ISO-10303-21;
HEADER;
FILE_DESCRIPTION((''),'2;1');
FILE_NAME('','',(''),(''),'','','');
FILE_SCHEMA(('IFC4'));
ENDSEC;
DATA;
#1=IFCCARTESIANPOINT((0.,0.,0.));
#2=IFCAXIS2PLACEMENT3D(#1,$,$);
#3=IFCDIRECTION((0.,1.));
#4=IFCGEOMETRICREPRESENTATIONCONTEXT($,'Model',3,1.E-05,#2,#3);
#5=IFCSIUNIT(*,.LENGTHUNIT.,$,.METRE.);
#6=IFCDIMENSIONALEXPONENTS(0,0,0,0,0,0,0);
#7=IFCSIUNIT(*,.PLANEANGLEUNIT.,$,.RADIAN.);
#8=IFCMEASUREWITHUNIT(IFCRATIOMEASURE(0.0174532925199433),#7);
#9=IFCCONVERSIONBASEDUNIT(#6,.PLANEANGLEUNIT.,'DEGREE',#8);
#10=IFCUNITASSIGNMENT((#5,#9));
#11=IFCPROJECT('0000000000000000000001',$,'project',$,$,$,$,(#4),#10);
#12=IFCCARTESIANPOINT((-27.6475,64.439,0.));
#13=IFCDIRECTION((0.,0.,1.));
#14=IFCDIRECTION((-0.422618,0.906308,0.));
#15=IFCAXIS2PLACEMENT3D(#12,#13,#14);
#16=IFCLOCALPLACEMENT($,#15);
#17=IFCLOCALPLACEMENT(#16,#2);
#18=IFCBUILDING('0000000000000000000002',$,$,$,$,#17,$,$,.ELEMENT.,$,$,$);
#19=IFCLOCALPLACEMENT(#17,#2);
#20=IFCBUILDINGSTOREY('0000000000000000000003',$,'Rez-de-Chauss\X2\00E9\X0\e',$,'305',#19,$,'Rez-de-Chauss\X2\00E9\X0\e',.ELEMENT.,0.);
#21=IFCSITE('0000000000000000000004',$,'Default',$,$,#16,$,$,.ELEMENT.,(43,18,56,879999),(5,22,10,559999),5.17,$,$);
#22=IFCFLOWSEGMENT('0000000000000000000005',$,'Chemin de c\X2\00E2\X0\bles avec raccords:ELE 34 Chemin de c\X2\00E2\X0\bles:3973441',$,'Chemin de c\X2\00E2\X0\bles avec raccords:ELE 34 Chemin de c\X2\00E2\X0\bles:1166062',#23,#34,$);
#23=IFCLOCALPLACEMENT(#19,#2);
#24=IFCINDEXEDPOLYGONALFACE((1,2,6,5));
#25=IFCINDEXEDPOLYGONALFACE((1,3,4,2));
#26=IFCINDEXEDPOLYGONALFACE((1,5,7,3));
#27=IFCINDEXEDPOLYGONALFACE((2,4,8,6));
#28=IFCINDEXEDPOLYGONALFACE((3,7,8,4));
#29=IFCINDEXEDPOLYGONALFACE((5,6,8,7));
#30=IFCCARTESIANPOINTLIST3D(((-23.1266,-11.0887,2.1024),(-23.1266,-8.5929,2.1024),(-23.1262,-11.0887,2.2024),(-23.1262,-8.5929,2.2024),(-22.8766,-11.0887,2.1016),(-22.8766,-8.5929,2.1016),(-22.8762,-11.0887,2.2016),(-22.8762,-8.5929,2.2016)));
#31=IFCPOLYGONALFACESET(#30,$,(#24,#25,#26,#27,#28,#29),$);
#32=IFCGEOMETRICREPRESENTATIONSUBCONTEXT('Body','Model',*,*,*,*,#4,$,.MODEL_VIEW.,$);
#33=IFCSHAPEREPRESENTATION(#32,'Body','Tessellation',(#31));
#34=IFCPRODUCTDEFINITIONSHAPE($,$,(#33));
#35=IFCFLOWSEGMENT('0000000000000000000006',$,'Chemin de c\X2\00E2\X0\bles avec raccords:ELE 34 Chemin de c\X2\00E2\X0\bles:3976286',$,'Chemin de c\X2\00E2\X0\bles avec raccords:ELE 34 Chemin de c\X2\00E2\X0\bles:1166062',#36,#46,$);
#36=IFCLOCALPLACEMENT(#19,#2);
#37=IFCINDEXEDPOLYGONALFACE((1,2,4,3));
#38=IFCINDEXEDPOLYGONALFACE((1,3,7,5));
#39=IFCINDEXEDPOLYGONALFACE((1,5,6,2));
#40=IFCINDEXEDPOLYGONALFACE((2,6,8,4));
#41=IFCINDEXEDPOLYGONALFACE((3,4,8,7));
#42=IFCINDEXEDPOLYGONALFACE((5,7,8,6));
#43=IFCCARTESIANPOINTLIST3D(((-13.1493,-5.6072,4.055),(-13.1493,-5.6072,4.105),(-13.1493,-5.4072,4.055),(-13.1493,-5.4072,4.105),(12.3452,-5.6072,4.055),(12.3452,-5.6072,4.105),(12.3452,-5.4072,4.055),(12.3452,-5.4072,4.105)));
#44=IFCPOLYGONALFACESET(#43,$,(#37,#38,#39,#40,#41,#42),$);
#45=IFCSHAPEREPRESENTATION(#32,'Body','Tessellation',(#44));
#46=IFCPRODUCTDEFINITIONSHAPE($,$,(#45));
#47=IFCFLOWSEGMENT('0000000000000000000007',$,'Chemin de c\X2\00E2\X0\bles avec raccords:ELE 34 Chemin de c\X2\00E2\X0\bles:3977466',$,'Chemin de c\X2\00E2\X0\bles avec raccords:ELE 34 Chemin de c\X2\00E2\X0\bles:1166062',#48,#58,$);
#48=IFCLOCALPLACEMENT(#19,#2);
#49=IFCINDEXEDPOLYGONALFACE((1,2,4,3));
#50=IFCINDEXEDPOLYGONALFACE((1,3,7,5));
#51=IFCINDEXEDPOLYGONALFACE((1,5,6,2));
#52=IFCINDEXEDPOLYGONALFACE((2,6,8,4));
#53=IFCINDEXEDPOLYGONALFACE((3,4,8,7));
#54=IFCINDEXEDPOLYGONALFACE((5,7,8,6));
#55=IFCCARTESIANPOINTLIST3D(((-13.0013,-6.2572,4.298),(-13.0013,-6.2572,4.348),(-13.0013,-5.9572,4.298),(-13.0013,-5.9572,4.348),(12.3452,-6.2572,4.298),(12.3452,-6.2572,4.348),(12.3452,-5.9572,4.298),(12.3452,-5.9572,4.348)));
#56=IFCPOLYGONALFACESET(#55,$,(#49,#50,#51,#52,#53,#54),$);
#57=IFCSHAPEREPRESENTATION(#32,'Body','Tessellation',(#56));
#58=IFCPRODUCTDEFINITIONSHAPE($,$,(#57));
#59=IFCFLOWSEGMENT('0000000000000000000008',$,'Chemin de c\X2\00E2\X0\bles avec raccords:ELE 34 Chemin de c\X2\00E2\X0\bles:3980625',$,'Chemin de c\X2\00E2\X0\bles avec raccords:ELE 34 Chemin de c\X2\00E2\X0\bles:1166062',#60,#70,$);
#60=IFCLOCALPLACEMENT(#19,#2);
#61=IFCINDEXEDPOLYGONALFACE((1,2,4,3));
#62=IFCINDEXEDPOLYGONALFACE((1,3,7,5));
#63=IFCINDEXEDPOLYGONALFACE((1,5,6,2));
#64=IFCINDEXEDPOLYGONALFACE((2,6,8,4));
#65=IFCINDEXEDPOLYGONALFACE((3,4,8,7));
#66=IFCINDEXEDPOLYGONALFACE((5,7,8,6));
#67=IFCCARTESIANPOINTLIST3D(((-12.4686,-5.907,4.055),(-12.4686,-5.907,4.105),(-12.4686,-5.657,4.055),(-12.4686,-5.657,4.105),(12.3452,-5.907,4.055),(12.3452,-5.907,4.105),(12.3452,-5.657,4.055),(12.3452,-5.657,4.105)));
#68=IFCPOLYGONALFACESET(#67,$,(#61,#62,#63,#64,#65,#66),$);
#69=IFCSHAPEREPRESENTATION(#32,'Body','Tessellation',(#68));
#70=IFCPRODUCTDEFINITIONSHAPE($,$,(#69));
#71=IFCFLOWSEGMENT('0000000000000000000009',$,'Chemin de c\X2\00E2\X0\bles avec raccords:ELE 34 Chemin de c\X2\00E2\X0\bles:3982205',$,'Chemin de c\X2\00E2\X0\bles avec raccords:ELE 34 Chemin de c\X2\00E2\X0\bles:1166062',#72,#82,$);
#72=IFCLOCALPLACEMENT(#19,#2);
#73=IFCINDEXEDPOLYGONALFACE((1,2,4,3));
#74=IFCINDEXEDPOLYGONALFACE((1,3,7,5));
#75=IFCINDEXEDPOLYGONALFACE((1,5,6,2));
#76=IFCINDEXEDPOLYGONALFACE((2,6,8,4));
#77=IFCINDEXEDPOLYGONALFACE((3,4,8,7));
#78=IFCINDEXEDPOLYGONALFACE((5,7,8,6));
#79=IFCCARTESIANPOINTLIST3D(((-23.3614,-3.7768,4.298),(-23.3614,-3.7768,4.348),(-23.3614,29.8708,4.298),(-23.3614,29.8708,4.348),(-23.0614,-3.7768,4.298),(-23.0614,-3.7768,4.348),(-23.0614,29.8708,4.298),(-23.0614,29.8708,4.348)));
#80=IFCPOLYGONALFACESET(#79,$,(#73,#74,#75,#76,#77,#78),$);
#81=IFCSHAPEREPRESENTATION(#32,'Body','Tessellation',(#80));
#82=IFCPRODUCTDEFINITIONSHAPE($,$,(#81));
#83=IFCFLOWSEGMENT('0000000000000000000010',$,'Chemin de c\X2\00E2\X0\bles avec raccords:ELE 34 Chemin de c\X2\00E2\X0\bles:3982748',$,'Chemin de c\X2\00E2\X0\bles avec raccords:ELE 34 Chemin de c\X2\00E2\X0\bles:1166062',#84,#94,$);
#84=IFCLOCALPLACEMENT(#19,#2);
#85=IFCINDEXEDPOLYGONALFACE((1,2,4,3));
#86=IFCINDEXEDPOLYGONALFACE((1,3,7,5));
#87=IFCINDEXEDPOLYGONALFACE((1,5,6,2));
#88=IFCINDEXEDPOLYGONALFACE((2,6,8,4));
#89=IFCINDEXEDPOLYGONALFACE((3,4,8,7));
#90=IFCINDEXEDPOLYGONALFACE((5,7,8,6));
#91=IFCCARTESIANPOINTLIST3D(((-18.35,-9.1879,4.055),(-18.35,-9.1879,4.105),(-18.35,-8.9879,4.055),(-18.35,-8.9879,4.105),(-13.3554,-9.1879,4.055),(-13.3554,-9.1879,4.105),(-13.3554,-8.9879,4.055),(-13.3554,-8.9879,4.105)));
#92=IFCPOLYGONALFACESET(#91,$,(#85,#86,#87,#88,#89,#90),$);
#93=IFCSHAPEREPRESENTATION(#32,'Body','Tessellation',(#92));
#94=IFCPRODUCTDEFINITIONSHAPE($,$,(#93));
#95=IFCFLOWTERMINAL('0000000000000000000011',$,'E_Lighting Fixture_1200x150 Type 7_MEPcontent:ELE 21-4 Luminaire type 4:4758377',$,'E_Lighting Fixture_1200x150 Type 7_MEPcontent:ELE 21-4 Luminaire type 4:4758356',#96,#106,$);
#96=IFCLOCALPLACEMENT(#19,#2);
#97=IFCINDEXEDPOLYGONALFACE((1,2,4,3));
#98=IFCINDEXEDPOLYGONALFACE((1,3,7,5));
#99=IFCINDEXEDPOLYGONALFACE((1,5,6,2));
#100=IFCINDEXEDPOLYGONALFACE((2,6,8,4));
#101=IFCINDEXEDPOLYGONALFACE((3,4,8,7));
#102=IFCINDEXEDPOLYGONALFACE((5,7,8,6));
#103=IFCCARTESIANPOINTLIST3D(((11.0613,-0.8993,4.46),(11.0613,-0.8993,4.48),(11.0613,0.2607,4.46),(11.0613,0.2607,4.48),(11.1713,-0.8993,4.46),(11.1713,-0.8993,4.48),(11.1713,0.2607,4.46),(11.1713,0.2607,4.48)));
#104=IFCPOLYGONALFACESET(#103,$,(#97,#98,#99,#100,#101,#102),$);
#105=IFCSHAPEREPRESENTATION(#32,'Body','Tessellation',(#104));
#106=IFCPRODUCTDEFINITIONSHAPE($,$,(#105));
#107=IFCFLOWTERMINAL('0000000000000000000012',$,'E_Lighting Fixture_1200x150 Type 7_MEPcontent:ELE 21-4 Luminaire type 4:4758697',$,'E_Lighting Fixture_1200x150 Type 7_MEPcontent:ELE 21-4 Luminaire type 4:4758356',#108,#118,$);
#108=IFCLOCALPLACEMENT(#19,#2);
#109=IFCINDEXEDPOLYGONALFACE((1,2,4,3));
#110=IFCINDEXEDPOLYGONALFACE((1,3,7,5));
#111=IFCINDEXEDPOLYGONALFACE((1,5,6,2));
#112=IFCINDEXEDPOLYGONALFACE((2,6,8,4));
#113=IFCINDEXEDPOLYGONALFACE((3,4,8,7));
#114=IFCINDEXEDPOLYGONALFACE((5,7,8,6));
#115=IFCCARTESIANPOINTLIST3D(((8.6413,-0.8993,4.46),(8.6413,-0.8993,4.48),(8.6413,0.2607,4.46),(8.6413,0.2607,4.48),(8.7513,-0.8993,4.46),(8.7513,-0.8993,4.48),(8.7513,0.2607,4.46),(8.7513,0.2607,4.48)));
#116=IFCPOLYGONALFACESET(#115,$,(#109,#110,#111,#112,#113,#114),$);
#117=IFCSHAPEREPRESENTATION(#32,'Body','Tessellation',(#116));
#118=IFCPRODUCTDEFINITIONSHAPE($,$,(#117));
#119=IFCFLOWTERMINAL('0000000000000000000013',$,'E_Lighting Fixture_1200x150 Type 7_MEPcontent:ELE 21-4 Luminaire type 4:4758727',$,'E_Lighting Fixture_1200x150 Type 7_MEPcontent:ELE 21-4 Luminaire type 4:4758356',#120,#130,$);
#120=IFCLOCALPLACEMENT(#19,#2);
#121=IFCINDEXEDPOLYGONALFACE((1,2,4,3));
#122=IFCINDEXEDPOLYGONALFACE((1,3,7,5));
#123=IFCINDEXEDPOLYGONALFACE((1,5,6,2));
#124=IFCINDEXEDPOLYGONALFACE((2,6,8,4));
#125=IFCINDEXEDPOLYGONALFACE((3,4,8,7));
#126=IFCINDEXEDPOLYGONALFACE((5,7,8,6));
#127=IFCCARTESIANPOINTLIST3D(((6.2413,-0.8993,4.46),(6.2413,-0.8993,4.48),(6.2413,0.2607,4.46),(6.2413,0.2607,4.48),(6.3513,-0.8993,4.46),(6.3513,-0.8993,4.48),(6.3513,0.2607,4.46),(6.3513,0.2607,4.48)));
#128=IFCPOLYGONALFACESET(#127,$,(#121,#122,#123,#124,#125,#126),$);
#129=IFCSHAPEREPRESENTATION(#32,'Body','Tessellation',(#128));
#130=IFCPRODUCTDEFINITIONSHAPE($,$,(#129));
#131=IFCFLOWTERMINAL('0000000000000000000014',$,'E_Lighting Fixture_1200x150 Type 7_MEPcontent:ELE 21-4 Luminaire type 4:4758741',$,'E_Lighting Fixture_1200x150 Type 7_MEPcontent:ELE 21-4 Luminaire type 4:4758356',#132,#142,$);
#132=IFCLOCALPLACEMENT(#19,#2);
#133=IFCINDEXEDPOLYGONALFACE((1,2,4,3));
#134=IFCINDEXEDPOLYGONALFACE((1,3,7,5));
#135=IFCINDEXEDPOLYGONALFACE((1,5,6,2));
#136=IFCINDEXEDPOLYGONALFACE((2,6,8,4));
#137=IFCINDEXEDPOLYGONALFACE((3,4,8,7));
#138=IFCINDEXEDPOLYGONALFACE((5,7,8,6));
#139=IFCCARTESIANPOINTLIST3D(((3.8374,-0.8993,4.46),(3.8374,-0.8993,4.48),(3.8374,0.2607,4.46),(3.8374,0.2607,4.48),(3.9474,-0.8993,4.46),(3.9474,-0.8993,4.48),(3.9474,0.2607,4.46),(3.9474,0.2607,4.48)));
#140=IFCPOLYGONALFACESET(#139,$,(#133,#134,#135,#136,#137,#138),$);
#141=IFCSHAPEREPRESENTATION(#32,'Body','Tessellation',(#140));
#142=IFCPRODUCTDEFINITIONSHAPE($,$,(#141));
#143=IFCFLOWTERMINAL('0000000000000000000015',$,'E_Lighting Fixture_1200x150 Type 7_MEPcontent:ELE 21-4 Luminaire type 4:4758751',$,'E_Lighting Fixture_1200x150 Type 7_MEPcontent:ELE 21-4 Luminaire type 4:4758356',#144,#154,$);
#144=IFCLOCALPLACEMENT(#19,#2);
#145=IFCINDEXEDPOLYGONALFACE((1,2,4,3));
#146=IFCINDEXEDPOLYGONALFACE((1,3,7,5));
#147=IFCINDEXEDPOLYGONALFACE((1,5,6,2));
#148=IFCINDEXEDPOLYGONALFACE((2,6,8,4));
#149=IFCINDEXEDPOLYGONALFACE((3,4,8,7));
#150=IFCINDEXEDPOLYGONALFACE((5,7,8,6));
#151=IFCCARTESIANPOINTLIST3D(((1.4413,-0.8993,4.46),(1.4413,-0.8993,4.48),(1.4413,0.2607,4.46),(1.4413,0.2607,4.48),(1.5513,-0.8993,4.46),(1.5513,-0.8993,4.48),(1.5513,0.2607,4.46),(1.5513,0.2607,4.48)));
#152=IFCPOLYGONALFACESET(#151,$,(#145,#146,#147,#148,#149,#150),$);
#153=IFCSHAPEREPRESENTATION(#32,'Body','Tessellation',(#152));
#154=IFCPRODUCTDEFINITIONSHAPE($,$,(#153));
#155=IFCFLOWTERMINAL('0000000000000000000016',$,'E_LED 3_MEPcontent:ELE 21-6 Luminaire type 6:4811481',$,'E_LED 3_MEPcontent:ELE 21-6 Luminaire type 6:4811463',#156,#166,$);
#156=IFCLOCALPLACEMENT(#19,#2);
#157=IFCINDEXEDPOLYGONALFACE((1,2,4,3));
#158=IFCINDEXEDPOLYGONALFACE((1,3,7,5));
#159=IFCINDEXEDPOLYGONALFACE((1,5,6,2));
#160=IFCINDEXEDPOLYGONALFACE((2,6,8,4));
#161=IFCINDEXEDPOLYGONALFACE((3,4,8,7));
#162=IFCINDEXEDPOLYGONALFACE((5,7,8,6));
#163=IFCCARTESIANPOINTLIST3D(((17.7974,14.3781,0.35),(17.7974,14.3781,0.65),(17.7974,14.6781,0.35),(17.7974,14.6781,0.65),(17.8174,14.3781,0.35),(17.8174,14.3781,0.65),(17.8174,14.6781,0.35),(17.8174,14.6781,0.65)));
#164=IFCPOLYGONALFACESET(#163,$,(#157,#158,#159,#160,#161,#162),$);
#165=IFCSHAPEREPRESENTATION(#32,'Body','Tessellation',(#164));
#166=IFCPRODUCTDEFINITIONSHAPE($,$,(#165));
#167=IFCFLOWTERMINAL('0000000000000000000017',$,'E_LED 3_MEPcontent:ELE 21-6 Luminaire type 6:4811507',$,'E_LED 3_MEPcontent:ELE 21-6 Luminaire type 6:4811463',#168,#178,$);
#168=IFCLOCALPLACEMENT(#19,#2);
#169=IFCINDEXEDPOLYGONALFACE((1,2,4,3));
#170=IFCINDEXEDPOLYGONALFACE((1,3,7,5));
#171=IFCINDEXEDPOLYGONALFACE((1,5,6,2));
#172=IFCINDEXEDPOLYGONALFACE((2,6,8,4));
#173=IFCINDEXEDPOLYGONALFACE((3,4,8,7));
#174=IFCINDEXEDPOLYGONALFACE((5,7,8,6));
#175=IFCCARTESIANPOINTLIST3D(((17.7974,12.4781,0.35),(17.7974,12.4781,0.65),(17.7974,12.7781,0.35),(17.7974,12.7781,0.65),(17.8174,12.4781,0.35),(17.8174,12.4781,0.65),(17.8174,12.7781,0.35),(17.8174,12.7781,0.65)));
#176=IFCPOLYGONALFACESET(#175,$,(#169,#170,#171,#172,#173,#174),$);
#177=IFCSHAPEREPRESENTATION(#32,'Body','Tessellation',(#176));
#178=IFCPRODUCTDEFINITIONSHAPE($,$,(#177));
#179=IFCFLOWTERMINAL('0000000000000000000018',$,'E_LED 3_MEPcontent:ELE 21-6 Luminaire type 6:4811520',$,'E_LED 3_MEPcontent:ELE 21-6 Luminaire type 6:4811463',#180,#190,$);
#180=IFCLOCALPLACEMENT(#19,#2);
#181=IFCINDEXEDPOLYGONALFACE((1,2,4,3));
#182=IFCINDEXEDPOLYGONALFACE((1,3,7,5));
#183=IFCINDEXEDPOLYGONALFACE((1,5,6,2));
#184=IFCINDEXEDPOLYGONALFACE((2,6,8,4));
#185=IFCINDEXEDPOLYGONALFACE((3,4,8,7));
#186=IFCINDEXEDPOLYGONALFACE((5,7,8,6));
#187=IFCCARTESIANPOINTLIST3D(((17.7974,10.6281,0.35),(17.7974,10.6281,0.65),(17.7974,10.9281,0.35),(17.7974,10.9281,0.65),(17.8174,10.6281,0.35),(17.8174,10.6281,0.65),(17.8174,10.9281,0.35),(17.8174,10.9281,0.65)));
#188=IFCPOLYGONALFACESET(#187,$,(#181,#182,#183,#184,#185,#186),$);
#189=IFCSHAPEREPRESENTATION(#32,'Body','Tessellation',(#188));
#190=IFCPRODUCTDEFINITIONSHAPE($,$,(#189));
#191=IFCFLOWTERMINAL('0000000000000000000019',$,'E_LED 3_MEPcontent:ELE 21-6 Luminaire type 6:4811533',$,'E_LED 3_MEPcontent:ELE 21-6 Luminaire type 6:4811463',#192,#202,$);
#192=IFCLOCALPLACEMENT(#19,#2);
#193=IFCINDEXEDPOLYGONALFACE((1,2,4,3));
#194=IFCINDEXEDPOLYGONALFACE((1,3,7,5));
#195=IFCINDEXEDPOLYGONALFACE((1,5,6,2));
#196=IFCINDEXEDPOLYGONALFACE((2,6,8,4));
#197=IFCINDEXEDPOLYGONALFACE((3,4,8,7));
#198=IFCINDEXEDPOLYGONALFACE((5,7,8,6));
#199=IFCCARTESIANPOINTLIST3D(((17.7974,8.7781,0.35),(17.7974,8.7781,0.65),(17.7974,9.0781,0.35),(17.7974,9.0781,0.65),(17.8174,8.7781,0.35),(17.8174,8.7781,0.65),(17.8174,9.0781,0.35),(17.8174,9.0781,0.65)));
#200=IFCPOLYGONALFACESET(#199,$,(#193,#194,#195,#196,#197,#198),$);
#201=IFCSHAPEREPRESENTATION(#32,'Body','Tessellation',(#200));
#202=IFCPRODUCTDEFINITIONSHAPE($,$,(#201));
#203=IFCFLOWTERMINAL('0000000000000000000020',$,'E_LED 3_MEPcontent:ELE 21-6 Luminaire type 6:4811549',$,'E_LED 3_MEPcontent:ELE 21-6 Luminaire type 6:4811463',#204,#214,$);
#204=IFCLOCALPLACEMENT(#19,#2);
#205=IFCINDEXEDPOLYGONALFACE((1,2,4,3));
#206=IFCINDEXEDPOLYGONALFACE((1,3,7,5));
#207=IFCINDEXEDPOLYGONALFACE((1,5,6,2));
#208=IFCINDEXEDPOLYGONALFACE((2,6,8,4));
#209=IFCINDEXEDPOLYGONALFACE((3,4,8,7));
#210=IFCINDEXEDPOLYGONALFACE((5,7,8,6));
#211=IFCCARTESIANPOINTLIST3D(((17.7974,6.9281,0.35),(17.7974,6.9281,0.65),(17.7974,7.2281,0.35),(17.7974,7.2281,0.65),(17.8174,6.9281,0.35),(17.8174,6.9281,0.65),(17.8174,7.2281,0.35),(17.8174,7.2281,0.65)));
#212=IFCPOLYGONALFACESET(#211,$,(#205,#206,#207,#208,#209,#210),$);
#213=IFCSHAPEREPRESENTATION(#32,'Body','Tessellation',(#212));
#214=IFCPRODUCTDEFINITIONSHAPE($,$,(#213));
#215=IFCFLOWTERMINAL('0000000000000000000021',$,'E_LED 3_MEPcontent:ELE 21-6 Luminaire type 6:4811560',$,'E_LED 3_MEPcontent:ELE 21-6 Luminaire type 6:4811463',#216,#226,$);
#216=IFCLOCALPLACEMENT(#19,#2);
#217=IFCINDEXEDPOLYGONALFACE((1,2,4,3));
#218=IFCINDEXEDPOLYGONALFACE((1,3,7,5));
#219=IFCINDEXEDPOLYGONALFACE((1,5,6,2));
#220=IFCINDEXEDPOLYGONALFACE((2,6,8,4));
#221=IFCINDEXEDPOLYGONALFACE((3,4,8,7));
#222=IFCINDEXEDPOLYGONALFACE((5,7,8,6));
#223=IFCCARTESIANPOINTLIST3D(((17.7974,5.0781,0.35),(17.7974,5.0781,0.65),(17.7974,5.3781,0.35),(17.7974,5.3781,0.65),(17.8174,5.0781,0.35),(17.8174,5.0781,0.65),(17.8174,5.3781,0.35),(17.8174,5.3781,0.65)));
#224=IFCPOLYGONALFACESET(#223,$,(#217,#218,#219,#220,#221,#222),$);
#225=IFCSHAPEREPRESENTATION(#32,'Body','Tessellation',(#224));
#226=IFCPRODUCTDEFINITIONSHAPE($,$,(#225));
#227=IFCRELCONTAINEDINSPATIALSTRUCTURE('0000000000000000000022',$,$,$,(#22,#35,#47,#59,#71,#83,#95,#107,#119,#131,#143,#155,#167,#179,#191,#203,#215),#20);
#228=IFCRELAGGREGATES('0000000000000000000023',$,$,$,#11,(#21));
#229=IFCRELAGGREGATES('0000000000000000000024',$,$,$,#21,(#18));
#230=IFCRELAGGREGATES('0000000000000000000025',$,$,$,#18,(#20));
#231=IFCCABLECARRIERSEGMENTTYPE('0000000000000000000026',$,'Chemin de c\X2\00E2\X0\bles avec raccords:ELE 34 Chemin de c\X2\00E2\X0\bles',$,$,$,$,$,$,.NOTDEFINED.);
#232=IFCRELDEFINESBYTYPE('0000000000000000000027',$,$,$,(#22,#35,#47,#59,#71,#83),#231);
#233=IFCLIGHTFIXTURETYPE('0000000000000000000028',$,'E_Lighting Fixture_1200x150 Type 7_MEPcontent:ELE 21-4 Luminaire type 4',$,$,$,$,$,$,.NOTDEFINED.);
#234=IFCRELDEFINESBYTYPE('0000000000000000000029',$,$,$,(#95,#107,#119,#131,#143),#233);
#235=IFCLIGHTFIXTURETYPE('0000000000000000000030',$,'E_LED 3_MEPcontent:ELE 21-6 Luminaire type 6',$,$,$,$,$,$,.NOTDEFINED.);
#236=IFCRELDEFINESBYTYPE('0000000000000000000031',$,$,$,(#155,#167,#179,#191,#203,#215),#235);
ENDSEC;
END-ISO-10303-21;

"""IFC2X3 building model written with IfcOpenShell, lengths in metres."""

from ifc_helpers import new_model, entity, si_unit, converted_unit, direction, frame, frame_2d, origin, origin_2d_with_axis, place, context, subcontext, project, spatial, rectangle, extrude, source, transform, mapped, type_object, type_shapes, element, save


model = new_model("IFC2X3")

# Units and contexts
model_context = context("Model", 3, precision=1e-05, world=origin(), true_north=direction((0.0, 1.0)))
body_context = subcontext(model_context, "Body", "Model", "MODEL_VIEW")
ifc_project = project(units=[si_unit("LENGTHUNIT", "METRE"), converted_unit("PLANEANGLEUNIT", "DEGREE", entity("IfcRatioMeasure", 0.0174532925199433), si_unit("PLANEANGLEUNIT", "RADIAN"), dimensions=[0, 0, 0, 0, 0, 0, 0])], contexts=[model_context])

# Site, building, storey
site_placement = place(None, frame((-27.6475, 64.439, 0.0), z_axis=(0.0, 0.0, 1.0), x_axis=(-0.422618, 0.906308, 0.0)))
site = spatial("IfcSite", under=ifc_project, at=site_placement, Name="Default", CompositionType="ELEMENT", RefLatitude=(43, 18, 56, 879999), RefLongitude=(5, 22, 10, 559999), RefElevation=5.17)
building_placement = place(site_placement, origin())
building = spatial("IfcBuilding", under=site, at=building_placement, CompositionType="ELEMENT")
storey_placement = place(building_placement, origin())
storey = spatial("IfcBuildingStorey", under=building, at=storey_placement, Name="Rez-de-Chaussée", ObjectType="305", LongName="Rez-de-Chaussée", CompositionType="ELEMENT", Elevation=0.0)

# Flow segments
cable_carrier_segment_type = type_object("IfcCableCarrierSegmentType", Name="Chemin de câbles avec raccords:ELE 34 Chemin de câbles", PredefinedType="NOTDEFINED")
flow_segment_1_placement = place(storey_placement, origin())
element("IfcFlowSegment", 1, at=flow_segment_1_placement, inside=storey, type_object=cable_carrier_segment_type, Name="Chemin de câbles avec raccords:ELE 34 Chemin de câbles:3973441", ObjectType="Chemin de câbles avec raccords:ELE 34 Chemin de câbles:1166062", context=body_context, shape_type="SweptSolid", body=[
    extrude(rectangle(XDim=0.25, YDim=2.4958, at=frame_2d((0.0, 0.0), x_axis=(0.0, 1.0))), frame((-23.0016, -9.8408, 2.102), z_axis=(0.003415, -0.000006, 0.999994), x_axis=(0.0, 1.0, 0.000006)), (0.0, 0.0, 1.0), 0.1),
])
flow_segment_2_placement = place(storey_placement, origin())
element("IfcFlowSegment", 2, at=flow_segment_2_placement, inside=storey, type_object=cable_carrier_segment_type, Name="Chemin de câbles avec raccords:ELE 34 Chemin de câbles:3976286", ObjectType="Chemin de câbles avec raccords:ELE 34 Chemin de câbles:1166062", context=body_context, shape_type="SweptSolid", body=[
    extrude(rectangle(XDim=0.2, YDim=25.4945, at=origin_2d_with_axis()), frame((-0.4021, -5.5072, 4.055), z_axis=(0.0, 0.0, 1.0), x_axis=(0.0, -1.0, 0.0)), (0.0, 0.0, 1.0), 0.05),
])
flow_segment_3_placement = place(storey_placement, origin())
element("IfcFlowSegment", 3, at=flow_segment_3_placement, inside=storey, type_object=cable_carrier_segment_type, Name="Chemin de câbles avec raccords:ELE 34 Chemin de câbles:3977466", ObjectType="Chemin de câbles avec raccords:ELE 34 Chemin de câbles:1166062", context=body_context, shape_type="SweptSolid", body=[
    extrude(rectangle(XDim=25.3464, YDim=0.3, at=origin_2d_with_axis()), frame((-0.3281, -6.1072, 4.298), z_axis=(0.0, 0.0, 1.0), x_axis=(-1.0, 0.0, 0.0)), (0.0, 0.0, 1.0), 0.05),
])
flow_segment_4_placement = place(storey_placement, origin())
element("IfcFlowSegment", 4, at=flow_segment_4_placement, inside=storey, type_object=cable_carrier_segment_type, Name="Chemin de câbles avec raccords:ELE 34 Chemin de câbles:3980625", ObjectType="Chemin de câbles avec raccords:ELE 34 Chemin de câbles:1166062", context=body_context, shape_type="SweptSolid", body=[
    extrude(rectangle(XDim=24.8138, YDim=0.25, at=origin_2d_with_axis()), frame((-0.0617, -5.782, 4.055)), (0.0, 0.0, 1.0), 0.05),
])
flow_segment_5_placement = place(storey_placement, origin())
element("IfcFlowSegment", 5, at=flow_segment_5_placement, inside=storey, type_object=cable_carrier_segment_type, Name="Chemin de câbles avec raccords:ELE 34 Chemin de câbles:3982205", ObjectType="Chemin de câbles avec raccords:ELE 34 Chemin de câbles:1166062", context=body_context, shape_type="SweptSolid", body=[
    extrude(rectangle(XDim=33.6476, YDim=0.3, at=origin_2d_with_axis()), frame((-23.2114, 13.047, 4.298), z_axis=(0.0, 0.0, 1.0), x_axis=(0.0, 1.0, 0.0)), (0.0, 0.0, 1.0), 0.05),
])
flow_segment_6_placement = place(storey_placement, origin())
element("IfcFlowSegment", 6, at=flow_segment_6_placement, inside=storey, type_object=cable_carrier_segment_type, Name="Chemin de câbles avec raccords:ELE 34 Chemin de câbles:3982748", ObjectType="Chemin de câbles avec raccords:ELE 34 Chemin de câbles:1166062", context=body_context, shape_type="SweptSolid", body=[
    extrude(rectangle(XDim=4.9947, YDim=0.2, at=origin_2d_with_axis()), frame((-15.8527, -9.0879, 4.055), z_axis=(0.0, 0.0, 1.0), x_axis=(-1.0, 0.0, 0.0)), (0.0, 0.0, 1.0), 0.05),
])

# Flow terminals
light_fixture_type_1 = type_object("IfcLightFixtureType", Name="E_Lighting Fixture_1200x150 Type 7_MEPcontent:ELE 21-4 Luminaire type 4", PredefinedType="NOTDEFINED")
shared_shape_1 = source(origin(), body_context, "Body", "SweptSolid", [
    extrude(rectangle(XDim=0.11, YDim=1.16, at=origin_2d_with_axis()), frame((0.0, 0.0, 0.0), z_axis=(0.0, 0.0, 1.0), x_axis=(0.0, -1.0, 0.0)), (0.0, 0.0, 1.0), 0.02),
])
type_shapes(light_fixture_type_1, [shared_shape_1])
for number, where, z_axis, x_axis, name in (
    (7, (11.1163, -0.3193, 4.46), (0.0, 0.0, 1.0), (0.0, -1.0, 0.0), "E_Lighting Fixture_1200x150 Type 7_MEPcontent:ELE 21-4 Luminaire type 4:4758377"),
    (8, (8.6963, -0.3193, 4.46), (0.0, 0.0, 1.0), (0.0, -1.0, 0.0), "E_Lighting Fixture_1200x150 Type 7_MEPcontent:ELE 21-4 Luminaire type 4:4758697"),
    (9, (6.2963, -0.3193, 4.46), (0.0, 0.0, 1.0), (0.0, -1.0, 0.0), "E_Lighting Fixture_1200x150 Type 7_MEPcontent:ELE 21-4 Luminaire type 4:4758727"),
    (10, (3.8924, -0.3193, 4.46), (0.0, 0.0, 1.0), (0.0, -1.0, 0.0), "E_Lighting Fixture_1200x150 Type 7_MEPcontent:ELE 21-4 Luminaire type 4:4758741"),
    (11, (1.4963, -0.3193, 4.46), (0.0, 0.0, 1.0), (0.0, -1.0, 0.0), "E_Lighting Fixture_1200x150 Type 7_MEPcontent:ELE 21-4 Luminaire type 4:4758751"),
):
    element("IfcFlowTerminal", number, at=place(storey_placement, frame(where, z_axis=z_axis, x_axis=x_axis)), inside=storey, type_object=light_fixture_type_1, Name=name, ObjectType="E_Lighting Fixture_1200x150 Type 7_MEPcontent:ELE 21-4 Luminaire type 4:4758356", context=body_context, shape_type="MappedRepresentation", body=[
        mapped(shared_shape_1, transform((0.0, 0.0, 0.0), scale=1.0)),
    ])
light_fixture_type_2 = type_object("IfcLightFixtureType", Name="E_LED 3_MEPcontent:ELE 21-6 Luminaire type 6", PredefinedType="NOTDEFINED")
shared_shape_2 = source(origin(), body_context, "Body", "SweptSolid", [
    extrude(rectangle(XDim=0.02, YDim=0.3, at=origin_2d_with_axis()), frame((0.0, 0.01, -0.15), z_axis=(0.0, 0.0, 1.0), x_axis=(0.0, -1.0, 0.0)), (0.0, 0.0, 1.0), 0.3),
])
type_shapes(light_fixture_type_2, [shared_shape_2])
for number, where, z_axis, x_axis, name in (
    (12, (17.7974, 14.5281, 0.5), (0.0, 0.0, 1.0), (0.0, -1.0, 0.0), "E_LED 3_MEPcontent:ELE 21-6 Luminaire type 6:4811481"),
    (13, (17.7974, 12.6281, 0.5), (0.0, 0.0, 1.0), (0.0, -1.0, 0.0), "E_LED 3_MEPcontent:ELE 21-6 Luminaire type 6:4811507"),
    (14, (17.7974, 10.7781, 0.5), (0.0, 0.0, 1.0), (0.0, -1.0, 0.0), "E_LED 3_MEPcontent:ELE 21-6 Luminaire type 6:4811520"),
    (15, (17.7974, 8.9281, 0.5), (0.0, 0.0, 1.0), (0.0, -1.0, 0.0), "E_LED 3_MEPcontent:ELE 21-6 Luminaire type 6:4811533"),
    (16, (17.7974, 7.0781, 0.5), (0.0, 0.0, 1.0), (0.0, -1.0, 0.0), "E_LED 3_MEPcontent:ELE 21-6 Luminaire type 6:4811549"),
    (17, (17.7974, 5.2281, 0.5), (0.0, 0.0, 1.0), (0.0, -1.0, 0.0), "E_LED 3_MEPcontent:ELE 21-6 Luminaire type 6:4811560"),
):
    element("IfcFlowTerminal", number, at=place(storey_placement, frame(where, z_axis=z_axis, x_axis=x_axis)), inside=storey, type_object=light_fixture_type_2, Name=name, ObjectType="E_LED 3_MEPcontent:ELE 21-6 Luminaire type 6:4811463", context=body_context, shape_type="MappedRepresentation", body=[
        mapped(shared_shape_2, transform((0.0, 0.0, 0.0), scale=1.0)),
    ])

save(model, "model.ifc")
